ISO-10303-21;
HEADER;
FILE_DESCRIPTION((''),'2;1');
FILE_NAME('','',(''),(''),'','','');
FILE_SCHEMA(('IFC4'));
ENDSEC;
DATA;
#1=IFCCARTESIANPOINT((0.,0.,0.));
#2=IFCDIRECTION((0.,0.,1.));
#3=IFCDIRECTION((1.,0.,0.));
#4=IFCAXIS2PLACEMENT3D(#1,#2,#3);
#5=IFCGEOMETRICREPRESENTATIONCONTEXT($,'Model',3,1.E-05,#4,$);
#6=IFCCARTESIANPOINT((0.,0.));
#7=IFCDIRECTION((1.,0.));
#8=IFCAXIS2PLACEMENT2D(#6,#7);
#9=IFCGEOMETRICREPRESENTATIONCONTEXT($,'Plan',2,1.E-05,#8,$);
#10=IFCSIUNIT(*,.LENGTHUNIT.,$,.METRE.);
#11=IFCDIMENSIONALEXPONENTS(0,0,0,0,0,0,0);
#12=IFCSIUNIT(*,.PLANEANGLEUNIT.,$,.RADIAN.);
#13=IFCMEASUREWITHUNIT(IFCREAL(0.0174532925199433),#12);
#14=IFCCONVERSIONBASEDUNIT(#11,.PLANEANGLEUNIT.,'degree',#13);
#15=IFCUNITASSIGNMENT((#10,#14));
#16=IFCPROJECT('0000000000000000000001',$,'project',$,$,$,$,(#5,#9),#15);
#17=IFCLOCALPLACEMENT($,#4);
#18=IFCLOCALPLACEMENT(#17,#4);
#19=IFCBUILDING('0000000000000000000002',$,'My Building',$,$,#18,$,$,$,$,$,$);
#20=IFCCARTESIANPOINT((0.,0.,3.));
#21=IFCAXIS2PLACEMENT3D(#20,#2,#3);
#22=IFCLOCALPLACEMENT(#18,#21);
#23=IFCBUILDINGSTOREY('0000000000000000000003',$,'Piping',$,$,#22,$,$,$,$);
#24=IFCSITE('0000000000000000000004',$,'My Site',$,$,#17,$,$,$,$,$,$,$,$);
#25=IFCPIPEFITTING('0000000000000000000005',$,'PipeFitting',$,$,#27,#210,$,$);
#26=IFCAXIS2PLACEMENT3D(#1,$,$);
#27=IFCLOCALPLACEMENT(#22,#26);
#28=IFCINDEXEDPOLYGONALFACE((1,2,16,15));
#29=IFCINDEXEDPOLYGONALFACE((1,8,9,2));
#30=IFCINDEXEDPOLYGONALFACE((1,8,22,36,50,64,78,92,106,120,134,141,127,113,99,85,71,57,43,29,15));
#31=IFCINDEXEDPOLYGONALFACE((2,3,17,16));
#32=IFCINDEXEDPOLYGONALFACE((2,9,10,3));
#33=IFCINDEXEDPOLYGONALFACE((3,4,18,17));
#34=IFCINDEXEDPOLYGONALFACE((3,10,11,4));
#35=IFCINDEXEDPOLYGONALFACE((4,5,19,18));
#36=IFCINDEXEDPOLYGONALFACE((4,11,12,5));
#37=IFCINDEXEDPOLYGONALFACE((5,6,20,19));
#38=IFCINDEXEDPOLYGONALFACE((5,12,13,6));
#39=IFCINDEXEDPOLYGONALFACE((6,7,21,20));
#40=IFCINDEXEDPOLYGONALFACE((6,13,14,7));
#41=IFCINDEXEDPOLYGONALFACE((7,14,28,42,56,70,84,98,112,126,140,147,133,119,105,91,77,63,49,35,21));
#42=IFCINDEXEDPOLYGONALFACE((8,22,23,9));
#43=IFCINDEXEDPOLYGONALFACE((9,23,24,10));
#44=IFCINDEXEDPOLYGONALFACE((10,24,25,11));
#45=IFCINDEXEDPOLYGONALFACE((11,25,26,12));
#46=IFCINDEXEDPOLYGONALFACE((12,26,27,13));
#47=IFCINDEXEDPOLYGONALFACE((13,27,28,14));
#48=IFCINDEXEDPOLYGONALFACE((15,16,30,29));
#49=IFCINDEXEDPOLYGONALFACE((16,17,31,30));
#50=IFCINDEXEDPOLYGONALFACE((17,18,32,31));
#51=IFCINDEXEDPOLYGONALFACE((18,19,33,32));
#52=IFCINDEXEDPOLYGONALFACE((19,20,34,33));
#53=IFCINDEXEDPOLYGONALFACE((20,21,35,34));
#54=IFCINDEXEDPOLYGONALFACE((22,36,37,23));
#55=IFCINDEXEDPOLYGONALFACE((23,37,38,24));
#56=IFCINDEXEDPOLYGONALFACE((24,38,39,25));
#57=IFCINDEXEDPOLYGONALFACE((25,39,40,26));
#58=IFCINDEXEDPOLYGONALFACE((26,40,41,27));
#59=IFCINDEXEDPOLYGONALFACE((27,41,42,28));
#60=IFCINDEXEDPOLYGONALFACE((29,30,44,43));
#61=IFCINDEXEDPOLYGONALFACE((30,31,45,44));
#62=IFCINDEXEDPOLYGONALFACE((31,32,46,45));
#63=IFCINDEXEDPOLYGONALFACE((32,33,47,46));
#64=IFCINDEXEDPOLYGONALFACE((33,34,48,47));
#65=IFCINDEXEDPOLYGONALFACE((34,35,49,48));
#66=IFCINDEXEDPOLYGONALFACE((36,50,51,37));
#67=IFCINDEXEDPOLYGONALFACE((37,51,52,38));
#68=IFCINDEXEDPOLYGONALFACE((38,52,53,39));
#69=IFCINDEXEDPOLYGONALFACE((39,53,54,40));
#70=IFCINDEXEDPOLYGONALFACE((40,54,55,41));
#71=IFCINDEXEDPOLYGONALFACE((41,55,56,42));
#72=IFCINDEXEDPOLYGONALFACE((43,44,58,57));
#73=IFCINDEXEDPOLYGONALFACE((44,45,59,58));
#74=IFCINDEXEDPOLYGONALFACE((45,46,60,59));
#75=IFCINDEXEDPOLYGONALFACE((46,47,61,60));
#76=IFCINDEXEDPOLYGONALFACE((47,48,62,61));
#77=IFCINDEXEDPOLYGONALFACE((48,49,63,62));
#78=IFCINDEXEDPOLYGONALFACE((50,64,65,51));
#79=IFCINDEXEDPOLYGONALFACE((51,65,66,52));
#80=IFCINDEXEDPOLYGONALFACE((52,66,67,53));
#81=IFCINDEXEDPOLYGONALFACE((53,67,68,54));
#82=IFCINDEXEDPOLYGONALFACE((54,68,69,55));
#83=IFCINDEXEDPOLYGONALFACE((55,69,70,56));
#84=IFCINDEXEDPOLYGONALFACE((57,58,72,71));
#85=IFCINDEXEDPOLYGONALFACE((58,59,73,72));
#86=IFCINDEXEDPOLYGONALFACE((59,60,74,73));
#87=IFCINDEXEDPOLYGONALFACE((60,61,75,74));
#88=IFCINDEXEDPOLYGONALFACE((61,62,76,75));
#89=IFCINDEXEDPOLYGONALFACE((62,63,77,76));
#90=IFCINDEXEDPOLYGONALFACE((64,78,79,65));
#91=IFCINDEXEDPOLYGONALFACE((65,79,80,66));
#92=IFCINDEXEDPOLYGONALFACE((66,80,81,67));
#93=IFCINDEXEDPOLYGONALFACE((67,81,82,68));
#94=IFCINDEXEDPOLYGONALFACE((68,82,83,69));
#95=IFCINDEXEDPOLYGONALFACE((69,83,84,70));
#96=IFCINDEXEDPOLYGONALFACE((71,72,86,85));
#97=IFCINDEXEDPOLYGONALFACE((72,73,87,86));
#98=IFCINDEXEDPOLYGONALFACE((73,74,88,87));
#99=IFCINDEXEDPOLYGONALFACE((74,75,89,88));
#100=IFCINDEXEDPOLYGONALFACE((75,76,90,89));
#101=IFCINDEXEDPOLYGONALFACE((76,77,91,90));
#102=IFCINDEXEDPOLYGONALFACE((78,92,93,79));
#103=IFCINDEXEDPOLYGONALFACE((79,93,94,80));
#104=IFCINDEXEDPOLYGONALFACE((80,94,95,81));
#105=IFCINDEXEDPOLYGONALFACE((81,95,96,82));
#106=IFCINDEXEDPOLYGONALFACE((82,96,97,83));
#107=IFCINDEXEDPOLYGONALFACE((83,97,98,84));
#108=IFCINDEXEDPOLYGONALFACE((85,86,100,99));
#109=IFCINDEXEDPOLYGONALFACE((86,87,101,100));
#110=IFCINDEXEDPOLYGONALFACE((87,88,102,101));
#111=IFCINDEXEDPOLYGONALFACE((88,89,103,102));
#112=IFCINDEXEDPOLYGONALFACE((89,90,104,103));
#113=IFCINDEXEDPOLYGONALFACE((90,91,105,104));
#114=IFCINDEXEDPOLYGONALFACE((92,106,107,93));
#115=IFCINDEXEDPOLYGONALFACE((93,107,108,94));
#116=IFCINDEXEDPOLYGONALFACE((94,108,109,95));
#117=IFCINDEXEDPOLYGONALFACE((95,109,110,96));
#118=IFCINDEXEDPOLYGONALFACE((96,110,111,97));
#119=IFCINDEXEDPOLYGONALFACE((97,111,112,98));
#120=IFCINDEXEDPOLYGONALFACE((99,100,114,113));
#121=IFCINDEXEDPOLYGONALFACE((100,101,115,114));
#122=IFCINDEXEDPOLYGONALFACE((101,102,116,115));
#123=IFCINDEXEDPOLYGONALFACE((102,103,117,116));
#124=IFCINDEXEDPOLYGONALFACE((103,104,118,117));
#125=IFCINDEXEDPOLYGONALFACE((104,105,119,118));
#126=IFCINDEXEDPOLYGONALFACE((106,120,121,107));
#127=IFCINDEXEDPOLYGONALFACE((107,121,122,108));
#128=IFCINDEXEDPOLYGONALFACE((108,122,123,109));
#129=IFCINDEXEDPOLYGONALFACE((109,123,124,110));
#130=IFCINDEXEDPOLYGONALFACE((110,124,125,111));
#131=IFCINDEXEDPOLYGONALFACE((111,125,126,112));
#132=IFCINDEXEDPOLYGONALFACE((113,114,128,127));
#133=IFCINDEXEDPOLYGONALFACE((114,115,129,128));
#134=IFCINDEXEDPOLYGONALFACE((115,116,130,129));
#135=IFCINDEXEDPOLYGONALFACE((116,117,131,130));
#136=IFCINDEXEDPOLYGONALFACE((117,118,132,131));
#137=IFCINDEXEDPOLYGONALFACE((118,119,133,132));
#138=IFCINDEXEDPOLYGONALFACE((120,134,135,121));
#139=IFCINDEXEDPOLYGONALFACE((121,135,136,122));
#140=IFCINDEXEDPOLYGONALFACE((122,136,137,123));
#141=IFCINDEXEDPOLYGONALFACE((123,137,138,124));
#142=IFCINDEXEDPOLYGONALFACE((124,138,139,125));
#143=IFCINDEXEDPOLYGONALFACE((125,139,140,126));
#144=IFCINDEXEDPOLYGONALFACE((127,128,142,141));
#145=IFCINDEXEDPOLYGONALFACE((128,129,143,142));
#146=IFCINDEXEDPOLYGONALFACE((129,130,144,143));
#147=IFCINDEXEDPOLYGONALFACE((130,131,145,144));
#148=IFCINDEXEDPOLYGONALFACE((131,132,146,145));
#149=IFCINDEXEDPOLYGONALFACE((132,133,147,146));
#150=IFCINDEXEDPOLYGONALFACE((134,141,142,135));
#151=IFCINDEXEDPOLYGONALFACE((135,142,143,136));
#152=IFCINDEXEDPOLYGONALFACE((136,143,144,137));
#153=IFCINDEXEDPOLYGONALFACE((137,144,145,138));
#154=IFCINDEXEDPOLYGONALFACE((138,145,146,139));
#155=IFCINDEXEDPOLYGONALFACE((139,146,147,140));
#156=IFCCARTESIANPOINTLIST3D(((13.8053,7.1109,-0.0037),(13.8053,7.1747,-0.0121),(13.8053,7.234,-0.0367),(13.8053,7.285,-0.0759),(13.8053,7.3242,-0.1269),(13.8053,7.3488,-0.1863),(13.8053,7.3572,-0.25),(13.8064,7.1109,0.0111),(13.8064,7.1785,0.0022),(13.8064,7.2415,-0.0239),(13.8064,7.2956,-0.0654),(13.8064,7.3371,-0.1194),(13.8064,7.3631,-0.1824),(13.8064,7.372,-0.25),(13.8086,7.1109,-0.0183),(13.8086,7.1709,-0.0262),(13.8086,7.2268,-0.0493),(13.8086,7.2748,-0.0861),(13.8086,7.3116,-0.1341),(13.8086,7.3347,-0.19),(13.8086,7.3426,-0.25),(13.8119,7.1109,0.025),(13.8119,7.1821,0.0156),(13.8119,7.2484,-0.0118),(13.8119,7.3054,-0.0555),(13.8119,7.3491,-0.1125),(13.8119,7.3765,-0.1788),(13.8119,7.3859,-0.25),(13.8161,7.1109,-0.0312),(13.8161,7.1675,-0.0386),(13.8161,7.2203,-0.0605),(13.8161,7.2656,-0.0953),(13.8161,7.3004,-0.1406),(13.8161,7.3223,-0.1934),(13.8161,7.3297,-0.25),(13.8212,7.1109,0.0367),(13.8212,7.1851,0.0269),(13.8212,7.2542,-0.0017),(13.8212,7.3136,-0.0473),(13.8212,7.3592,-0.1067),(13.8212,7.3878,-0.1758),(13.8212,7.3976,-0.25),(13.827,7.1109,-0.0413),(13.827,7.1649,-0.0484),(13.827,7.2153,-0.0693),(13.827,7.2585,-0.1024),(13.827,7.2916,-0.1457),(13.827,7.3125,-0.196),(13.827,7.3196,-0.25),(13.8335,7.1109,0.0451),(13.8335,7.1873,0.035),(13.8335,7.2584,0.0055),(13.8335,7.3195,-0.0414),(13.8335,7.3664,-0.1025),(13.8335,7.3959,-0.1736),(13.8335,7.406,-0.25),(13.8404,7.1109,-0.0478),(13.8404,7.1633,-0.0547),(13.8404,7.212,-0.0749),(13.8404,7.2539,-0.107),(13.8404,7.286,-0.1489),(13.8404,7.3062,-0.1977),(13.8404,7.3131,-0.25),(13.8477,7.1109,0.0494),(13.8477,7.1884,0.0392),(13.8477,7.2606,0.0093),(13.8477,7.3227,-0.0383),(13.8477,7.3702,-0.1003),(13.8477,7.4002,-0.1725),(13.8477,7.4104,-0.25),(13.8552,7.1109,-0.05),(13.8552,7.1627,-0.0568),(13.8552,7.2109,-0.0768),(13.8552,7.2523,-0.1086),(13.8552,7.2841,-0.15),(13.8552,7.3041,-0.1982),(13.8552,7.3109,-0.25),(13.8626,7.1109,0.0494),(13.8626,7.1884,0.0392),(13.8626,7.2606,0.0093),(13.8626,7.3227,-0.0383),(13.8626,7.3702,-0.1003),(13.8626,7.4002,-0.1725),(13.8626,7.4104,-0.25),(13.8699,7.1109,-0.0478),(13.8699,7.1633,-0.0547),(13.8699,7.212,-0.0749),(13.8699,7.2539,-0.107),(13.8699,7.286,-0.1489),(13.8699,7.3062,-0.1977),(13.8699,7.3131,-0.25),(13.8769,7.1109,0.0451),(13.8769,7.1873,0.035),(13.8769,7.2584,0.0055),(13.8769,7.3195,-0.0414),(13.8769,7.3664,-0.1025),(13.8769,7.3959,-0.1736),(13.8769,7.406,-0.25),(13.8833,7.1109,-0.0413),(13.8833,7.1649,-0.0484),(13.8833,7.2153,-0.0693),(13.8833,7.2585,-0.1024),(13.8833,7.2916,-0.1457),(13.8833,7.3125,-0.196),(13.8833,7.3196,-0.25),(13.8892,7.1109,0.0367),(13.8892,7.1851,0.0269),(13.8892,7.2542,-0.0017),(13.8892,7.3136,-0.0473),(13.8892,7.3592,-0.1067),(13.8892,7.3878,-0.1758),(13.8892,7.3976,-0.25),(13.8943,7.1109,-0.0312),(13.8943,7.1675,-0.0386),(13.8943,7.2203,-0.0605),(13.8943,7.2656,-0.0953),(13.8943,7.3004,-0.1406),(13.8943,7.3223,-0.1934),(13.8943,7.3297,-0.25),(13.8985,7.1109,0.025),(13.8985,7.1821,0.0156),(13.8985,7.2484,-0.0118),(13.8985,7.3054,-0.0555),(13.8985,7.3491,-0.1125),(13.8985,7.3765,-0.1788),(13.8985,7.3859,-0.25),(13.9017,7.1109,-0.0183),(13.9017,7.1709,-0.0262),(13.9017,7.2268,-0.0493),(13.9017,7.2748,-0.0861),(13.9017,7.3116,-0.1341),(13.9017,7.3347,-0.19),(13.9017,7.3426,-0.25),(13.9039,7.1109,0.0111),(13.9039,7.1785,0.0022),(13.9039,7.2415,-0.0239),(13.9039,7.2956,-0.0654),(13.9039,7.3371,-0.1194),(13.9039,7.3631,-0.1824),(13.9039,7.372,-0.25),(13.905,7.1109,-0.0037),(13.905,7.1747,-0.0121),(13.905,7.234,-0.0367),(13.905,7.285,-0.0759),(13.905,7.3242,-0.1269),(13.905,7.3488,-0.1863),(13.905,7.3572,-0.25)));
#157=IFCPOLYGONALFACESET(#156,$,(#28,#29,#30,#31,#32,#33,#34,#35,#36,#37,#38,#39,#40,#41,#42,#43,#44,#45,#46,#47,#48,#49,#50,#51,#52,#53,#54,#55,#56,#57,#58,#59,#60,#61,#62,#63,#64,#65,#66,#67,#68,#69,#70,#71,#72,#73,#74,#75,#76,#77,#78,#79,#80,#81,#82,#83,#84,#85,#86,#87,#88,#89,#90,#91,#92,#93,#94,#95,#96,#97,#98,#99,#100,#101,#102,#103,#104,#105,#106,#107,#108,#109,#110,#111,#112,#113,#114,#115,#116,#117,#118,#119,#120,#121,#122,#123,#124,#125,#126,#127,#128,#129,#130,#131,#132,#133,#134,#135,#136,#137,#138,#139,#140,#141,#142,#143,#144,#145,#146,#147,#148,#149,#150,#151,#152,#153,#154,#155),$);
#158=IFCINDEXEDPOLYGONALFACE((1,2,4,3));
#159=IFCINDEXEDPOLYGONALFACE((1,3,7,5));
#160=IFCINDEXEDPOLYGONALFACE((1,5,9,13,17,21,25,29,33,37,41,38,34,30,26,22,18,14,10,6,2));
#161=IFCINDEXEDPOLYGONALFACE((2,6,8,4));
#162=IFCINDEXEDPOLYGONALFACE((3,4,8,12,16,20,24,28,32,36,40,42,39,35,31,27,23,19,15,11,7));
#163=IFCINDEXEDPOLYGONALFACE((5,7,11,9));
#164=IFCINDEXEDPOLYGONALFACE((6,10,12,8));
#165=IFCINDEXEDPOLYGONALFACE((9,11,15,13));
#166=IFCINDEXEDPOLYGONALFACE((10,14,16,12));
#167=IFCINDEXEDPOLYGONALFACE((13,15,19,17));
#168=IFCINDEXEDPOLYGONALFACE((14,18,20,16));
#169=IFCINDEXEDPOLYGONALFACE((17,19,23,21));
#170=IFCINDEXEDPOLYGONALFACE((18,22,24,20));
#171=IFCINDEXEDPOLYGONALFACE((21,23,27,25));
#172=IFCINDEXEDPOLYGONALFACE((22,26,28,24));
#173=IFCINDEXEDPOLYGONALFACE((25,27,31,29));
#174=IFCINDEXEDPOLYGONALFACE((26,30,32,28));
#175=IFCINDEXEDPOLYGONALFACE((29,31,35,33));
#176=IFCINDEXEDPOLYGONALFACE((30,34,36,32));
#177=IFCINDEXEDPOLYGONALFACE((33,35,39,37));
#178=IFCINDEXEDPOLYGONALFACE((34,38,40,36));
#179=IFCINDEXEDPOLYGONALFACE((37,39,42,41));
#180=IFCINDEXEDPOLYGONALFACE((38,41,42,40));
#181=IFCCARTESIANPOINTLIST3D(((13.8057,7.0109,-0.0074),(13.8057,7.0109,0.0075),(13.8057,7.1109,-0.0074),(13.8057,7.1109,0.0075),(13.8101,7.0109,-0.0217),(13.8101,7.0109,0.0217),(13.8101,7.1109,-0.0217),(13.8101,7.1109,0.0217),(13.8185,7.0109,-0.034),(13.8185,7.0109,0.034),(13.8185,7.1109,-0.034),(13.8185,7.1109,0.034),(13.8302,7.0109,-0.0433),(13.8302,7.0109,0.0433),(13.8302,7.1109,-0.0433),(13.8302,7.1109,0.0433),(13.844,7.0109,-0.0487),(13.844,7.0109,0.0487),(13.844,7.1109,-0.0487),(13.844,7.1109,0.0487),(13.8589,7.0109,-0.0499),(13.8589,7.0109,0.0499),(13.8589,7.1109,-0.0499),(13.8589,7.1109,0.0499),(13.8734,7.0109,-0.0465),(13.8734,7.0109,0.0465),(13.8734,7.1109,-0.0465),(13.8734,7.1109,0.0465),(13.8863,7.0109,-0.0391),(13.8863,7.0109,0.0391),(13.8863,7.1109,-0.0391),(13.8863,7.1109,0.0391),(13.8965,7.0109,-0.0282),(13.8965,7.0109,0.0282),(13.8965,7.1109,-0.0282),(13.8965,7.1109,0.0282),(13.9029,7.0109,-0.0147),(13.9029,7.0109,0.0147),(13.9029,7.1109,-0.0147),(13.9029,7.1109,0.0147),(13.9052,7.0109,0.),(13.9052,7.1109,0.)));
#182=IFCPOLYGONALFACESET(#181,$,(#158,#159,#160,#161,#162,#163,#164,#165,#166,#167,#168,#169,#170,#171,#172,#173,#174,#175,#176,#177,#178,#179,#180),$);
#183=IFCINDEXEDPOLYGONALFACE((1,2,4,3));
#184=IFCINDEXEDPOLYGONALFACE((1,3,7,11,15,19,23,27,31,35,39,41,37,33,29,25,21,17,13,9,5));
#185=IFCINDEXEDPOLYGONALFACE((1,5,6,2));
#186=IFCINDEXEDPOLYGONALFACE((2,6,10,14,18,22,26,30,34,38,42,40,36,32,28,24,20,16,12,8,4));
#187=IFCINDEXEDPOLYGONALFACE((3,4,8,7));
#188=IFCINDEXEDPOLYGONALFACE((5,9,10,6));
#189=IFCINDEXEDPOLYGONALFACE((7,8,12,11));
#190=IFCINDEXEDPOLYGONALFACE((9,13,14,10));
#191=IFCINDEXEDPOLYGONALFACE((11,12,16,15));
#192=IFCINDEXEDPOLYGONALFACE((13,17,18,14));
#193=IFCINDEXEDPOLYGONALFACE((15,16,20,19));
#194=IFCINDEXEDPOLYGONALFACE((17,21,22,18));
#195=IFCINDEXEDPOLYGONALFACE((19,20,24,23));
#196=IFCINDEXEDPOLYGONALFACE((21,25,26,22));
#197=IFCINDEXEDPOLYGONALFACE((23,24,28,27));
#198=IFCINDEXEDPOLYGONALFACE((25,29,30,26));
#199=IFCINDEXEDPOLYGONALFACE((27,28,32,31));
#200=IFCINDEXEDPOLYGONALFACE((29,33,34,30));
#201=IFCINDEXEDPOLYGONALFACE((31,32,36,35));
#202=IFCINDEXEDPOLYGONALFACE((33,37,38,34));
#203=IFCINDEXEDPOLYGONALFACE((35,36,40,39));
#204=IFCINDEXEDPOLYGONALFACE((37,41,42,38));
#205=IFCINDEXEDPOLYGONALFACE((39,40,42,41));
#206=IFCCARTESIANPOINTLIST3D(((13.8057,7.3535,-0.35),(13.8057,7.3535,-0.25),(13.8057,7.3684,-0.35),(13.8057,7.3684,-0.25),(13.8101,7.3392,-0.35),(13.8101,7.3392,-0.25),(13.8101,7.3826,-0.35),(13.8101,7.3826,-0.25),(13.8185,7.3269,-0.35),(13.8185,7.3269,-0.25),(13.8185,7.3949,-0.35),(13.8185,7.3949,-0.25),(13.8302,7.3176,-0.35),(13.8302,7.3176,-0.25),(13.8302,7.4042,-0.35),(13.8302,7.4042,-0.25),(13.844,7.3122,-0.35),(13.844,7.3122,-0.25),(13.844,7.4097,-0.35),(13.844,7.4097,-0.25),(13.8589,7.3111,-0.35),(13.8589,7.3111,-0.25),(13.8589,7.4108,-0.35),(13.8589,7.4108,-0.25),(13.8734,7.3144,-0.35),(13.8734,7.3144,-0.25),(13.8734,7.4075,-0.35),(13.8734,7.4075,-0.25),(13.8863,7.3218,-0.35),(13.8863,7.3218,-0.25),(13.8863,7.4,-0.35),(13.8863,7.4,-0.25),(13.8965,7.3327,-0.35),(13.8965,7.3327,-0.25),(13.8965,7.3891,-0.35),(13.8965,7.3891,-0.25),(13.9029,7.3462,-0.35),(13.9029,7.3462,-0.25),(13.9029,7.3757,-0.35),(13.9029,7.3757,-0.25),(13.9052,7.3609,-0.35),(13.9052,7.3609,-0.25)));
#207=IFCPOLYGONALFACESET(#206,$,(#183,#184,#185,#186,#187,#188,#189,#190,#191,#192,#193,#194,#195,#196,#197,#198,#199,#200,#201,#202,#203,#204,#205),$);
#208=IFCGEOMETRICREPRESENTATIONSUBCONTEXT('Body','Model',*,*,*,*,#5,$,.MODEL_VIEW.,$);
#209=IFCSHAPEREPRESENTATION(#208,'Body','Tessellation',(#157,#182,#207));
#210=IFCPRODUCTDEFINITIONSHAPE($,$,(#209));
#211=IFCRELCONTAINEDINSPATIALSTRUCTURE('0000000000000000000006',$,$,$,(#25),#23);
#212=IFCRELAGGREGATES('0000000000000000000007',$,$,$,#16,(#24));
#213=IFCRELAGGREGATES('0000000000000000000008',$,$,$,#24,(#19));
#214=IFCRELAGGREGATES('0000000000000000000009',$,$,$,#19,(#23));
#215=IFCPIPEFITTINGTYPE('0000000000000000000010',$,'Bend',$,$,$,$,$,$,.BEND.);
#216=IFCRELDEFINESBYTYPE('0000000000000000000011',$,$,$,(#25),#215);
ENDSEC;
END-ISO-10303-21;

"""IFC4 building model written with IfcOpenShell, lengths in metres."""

from ifc_helpers import new_model, entity, si_unit, converted_unit, frame, origin_with_axes, origin_2d_with_axis, place, context, subcontext, project, spatial, circle, extrude, source, transform, mapped, type_object, type_shapes, element, save


model = new_model("IFC4")

# Units and contexts
model_context = context("Model", 3, precision=1e-05, world=origin_with_axes())
plan_context = context("Plan", 2, precision=1e-05, world=origin_2d_with_axis())
body_context = subcontext(model_context, "Body", "Model", "MODEL_VIEW")
ifc_project = project(units=[si_unit("LENGTHUNIT", "METRE"), converted_unit("PLANEANGLEUNIT", "degree", entity("IfcReal", 0.0174532925199433), si_unit("PLANEANGLEUNIT", "RADIAN"), dimensions=[0, 0, 0, 0, 0, 0, 0])], contexts=[model_context, plan_context])

# Site, building, storey
site_placement = place(None, origin_with_axes())
site = spatial("IfcSite", under=ifc_project, at=site_placement, Name="My Site")
building_placement = place(site_placement, origin_with_axes())
building = spatial("IfcBuilding", under=site, at=building_placement, Name="My Building")
storey_placement = place(building_placement, frame((0.0, 0.0, 3.0), z_axis=(0.0, 0.0, 1.0), x_axis=(1.0, 0.0, 0.0)))
storey = spatial("IfcBuildingStorey", under=building, at=storey_placement, Name="Piping")

# Pipe fitting
pipe_fitting_type = type_object("IfcPipeFittingType", Name="Bend", PredefinedType="BEND")
shared_shape = source(origin_with_axes(), body_context, "Body", "SolidModel", [
    entity("IfcSweptDiskSolid", entity("IfcIndexedPolyCurve", entity("IfcCartesianPointList3D", [[0.0, 0.0, -0.1], [0.0, -0.0732, -0.2768], [0.0, -0.25, -0.35]]), [entity("IfcArcIndex", [1, 2, 3])]), 0.05),
    extrude(circle(Radius=0.05), origin_with_axes(), (0.0, 0.0, -1.0), 0.1),
    extrude(circle(Radius=0.05), frame((0.0, -0.25, -0.35), z_axis=(0.0, -1.0, 0.0), x_axis=(1.0, 0.0, 0.0)), (0.0, 0.0, 1.0), 0.1),
])
type_shapes(pipe_fitting_type, [shared_shape])
for number, where, z_axis, x_axis, name in (
    (1, (13.8552, 7.0109, 0.0), (0.0, -1.0, 0.0), (1.0, 0.0, 0.0), "PipeFitting"),
):
    element("IfcPipeFitting", number, at=place(storey_placement, frame(where, z_axis=z_axis, x_axis=x_axis)), inside=storey, type_object=pipe_fitting_type, Name=name, context=body_context, shape_type="MappedRepresentation", body=[
        mapped(shared_shape, transform((0.0, 0.0, 0.0), x_axis=(1.0, 0.0, 0.0), y_axis=(0.0, 1.0, 0.0), z_axis=(0.0, 0.0, 1.0), scale=1.0)),
    ])

save(model, "model.ifc")
